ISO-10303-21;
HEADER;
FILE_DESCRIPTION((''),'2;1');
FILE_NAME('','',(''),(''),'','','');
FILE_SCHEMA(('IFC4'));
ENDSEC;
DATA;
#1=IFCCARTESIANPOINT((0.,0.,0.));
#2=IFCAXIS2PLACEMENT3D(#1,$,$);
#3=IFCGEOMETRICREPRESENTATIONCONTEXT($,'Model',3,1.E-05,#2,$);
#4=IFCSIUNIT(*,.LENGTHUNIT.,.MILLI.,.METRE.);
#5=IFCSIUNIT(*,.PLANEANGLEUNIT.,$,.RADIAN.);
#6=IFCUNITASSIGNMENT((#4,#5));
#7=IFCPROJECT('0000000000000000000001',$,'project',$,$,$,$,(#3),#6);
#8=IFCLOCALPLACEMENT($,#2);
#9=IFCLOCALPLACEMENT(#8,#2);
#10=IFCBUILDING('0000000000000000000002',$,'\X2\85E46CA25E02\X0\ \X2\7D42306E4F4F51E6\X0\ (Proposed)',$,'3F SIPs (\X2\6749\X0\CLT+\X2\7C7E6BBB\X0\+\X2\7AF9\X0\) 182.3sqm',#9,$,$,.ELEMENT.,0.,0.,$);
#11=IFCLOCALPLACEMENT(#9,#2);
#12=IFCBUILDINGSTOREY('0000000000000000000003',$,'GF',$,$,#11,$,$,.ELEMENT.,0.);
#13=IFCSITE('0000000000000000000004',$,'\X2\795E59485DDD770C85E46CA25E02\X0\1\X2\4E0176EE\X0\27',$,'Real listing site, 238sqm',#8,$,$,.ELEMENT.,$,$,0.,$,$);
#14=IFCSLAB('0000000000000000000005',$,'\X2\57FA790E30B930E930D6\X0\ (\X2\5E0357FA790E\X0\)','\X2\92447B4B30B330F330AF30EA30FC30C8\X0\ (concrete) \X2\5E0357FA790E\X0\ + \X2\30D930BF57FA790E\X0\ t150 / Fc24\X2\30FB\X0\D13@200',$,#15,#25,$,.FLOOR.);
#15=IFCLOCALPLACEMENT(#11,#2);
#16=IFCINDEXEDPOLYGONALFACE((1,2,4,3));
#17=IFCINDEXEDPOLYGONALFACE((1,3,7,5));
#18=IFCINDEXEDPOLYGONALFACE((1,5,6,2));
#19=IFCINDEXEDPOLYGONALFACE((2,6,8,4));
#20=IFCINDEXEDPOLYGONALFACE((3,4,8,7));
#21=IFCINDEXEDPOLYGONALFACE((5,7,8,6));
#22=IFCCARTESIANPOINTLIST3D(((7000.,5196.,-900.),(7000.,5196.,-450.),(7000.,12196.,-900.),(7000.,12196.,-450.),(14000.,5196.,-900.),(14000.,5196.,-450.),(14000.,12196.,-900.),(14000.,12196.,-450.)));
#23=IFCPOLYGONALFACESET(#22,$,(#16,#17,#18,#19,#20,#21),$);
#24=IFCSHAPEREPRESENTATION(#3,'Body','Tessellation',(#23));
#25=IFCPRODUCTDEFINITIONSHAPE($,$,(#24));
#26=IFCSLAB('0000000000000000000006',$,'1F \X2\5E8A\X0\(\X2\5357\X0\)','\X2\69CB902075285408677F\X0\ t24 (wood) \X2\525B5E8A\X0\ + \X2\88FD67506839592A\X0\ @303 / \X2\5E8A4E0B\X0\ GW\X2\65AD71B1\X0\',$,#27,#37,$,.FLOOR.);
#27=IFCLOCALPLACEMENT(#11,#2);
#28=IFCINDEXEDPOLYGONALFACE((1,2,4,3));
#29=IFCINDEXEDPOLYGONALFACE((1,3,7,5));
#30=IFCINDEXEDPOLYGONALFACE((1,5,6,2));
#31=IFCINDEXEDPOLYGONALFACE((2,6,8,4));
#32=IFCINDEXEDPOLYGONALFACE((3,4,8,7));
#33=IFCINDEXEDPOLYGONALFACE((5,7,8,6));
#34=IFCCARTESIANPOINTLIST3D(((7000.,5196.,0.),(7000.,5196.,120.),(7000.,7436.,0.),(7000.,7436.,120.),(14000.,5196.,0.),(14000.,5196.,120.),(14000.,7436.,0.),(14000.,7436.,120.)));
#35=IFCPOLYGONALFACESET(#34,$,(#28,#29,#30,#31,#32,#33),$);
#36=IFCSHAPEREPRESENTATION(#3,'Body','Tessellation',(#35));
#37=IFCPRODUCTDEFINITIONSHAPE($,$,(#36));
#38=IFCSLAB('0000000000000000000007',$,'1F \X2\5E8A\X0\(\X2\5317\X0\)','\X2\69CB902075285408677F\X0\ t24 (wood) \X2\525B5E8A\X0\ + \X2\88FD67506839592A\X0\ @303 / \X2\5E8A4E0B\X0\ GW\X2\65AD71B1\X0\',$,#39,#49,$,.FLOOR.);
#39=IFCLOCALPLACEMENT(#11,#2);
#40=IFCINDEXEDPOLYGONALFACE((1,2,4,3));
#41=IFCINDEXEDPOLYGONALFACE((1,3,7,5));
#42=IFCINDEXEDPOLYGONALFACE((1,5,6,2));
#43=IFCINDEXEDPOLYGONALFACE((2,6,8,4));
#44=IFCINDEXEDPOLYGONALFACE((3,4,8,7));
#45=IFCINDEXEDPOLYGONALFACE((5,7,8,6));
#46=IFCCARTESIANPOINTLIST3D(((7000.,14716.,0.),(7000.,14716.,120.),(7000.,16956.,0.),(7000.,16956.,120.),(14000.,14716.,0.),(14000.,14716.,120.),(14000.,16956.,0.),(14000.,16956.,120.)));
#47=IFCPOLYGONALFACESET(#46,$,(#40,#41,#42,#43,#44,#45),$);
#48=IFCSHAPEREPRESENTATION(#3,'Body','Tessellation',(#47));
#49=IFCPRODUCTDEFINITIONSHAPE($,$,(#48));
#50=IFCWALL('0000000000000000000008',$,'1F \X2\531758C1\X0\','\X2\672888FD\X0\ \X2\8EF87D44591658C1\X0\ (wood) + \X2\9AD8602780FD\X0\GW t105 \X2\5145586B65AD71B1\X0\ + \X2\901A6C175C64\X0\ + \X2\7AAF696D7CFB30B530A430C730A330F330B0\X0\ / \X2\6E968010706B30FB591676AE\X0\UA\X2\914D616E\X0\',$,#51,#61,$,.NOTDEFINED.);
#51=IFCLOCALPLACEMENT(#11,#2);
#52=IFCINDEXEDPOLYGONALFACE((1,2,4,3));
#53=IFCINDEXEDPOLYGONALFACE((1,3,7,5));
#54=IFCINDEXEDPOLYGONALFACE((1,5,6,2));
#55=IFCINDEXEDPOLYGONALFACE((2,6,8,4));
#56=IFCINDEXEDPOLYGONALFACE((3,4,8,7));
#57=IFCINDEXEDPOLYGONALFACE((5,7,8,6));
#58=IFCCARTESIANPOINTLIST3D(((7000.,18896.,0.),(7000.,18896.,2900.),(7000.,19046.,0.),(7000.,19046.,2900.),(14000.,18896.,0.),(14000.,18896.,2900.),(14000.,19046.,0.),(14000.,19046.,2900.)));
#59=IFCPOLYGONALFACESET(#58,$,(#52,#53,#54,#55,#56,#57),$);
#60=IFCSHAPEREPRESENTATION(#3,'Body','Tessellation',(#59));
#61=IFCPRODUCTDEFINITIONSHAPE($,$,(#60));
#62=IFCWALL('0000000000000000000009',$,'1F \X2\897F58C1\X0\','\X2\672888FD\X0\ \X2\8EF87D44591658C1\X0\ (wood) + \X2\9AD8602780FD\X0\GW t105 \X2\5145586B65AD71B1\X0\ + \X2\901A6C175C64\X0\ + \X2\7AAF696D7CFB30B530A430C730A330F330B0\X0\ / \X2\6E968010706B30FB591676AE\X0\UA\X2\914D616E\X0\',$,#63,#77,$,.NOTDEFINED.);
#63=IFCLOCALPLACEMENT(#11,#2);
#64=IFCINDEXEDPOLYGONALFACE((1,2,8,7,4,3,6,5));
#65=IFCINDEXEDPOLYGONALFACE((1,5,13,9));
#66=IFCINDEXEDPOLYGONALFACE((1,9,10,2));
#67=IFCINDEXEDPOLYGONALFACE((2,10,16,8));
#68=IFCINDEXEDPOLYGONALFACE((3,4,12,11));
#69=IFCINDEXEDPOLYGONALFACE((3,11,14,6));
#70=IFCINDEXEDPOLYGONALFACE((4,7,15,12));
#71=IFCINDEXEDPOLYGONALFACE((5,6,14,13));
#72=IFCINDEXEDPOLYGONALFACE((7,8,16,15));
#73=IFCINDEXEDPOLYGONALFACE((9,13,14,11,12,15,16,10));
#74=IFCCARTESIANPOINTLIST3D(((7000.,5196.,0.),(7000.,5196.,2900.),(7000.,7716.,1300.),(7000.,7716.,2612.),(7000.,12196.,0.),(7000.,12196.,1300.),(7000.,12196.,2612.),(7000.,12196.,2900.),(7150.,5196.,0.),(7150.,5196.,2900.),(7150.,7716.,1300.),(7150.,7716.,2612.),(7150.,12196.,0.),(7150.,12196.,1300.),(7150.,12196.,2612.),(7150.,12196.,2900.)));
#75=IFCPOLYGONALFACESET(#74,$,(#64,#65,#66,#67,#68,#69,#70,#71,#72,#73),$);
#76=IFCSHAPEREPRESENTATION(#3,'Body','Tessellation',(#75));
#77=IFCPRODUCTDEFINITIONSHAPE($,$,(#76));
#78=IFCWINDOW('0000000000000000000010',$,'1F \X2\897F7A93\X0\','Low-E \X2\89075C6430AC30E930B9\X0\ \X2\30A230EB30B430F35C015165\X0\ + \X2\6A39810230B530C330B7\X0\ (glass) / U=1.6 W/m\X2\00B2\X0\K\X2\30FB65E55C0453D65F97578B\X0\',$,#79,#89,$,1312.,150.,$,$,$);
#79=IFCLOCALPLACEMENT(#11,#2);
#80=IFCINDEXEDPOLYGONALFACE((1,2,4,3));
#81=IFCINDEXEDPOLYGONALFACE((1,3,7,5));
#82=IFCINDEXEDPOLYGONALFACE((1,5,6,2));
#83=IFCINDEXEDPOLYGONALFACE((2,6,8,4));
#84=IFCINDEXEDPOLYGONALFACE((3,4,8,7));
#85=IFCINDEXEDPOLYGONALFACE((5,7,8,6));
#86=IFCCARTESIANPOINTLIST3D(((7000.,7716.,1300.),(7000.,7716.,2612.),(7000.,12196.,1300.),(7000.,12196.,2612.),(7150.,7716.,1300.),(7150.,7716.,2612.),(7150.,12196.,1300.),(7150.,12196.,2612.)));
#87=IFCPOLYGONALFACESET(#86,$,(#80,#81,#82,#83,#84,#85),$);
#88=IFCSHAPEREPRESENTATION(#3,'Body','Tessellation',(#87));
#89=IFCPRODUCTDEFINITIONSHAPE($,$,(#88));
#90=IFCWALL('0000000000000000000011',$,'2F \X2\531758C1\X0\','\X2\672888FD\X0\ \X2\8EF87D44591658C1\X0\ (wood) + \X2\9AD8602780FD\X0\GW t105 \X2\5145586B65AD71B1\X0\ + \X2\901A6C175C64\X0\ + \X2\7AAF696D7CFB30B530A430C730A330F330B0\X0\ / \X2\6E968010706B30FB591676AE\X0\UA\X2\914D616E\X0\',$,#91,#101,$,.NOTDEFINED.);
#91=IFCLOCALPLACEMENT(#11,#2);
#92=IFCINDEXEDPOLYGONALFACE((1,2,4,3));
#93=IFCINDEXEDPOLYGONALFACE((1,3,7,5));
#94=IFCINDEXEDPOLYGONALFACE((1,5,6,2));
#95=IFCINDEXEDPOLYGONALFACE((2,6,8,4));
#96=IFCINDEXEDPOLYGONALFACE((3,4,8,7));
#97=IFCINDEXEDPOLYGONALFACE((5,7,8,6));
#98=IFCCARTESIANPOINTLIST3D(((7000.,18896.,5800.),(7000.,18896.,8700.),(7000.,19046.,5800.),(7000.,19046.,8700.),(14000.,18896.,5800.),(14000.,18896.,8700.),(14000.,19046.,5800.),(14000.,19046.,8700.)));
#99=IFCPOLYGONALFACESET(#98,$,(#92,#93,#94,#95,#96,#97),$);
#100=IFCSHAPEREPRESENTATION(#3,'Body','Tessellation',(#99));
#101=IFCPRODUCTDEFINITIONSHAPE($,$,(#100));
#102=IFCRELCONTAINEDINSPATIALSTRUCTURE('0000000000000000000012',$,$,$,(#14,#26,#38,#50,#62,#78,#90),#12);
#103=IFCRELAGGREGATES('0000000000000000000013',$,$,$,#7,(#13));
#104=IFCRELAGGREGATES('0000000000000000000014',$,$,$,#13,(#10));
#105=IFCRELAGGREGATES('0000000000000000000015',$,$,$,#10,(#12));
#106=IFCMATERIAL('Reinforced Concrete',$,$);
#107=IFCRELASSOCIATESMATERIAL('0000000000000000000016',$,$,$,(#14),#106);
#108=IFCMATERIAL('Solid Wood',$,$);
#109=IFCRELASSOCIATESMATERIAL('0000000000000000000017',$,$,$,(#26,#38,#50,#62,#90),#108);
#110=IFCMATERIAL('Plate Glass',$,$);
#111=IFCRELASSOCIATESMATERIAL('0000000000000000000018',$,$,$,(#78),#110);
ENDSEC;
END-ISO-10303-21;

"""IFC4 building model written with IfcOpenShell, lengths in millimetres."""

from ifc_helpers import new_model, si_unit, frame, frame_2d, origin, place, context, project, spatial, rectangle, extrude, material, element, fill, save


model = new_model("IFC4")

# Units and contexts
model_context = context("Model", 3, precision=1e-05, world=origin())
ifc_project = project(units=[si_unit("LENGTHUNIT", "METRE", prefix="MILLI"), si_unit("PLANEANGLEUNIT", "RADIAN")], contexts=[model_context])

# Site, building, storey
site_placement = place(None, origin())
site = spatial("IfcSite", under=ifc_project, at=site_placement, Name="神奈川県藤沢市1丁目27", ObjectType="Real listing site, 238sqm", CompositionType="ELEMENT", RefElevation=0.0)
building_placement = place(site_placement, origin())
building = spatial("IfcBuilding", under=site, at=building_placement, Name="藤沢市 終の住処 (Proposed)", ObjectType="3F SIPs (杉CLT+籾殻+竹) 182.3sqm", CompositionType="ELEMENT", ElevationOfRefHeight=0.0, ElevationOfTerrain=0.0)
storey_placement = place(building_placement, origin())
storey = spatial("IfcBuildingStorey", under=building, at=storey_placement, Name="GF", CompositionType="ELEMENT", Elevation=0.0)

# Slabs
ifc_material_1 = material(Name="Reinforced Concrete")
slab_1_placement = place(storey_placement, frame((3500.0, 2598.0, -450.0)))
element("IfcSlab", 1, at=slab_1_placement, inside=storey, material=ifc_material_1, Name="基礎スラブ (布基礎)", Description="鉄筋コンクリート (concrete) 布基礎 + ベタ基礎 t150 / Fc24・D13@200", PredefinedType="FLOOR", context=model_context, shape_type="SweptSolid", body=[
    extrude(rectangle(XDim=7000.0, YDim=7000.0, at=frame_2d((3500.0, 3500.0))), frame((3500.0, 2598.0, -450.0)), (0.0, 0.0, 1.0), 450.0),
])
ifc_material_2 = material(Name="Solid Wood")
slab_2_placement = place(storey_placement, frame((3500.0, 2598.0, 0.0)))
element("IfcSlab", 2, at=slab_2_placement, inside=storey, material=ifc_material_2, Name="1F 床(南)", Description="構造用合板 t24 (wood) 剛床 + 製材根太 @303 / 床下 GW断熱", PredefinedType="FLOOR", context=model_context, shape_type="SweptSolid", body=[
    extrude(rectangle(XDim=7000.0, YDim=2240.0, at=frame_2d((3500.0, 1120.0))), frame((3500.0, 2598.0, 0.0)), (0.0, 0.0, 1.0), 120.0),
])
slab_3_placement = place(storey_placement, frame((3500.0, 7358.0, 0.0)))
element("IfcSlab", 3, at=slab_3_placement, inside=storey, material=ifc_material_2, Name="1F 床(北)", Description="構造用合板 t24 (wood) 剛床 + 製材根太 @303 / 床下 GW断熱", PredefinedType="FLOOR", context=model_context, shape_type="SweptSolid", body=[
    extrude(rectangle(XDim=7000.0, YDim=2240.0, at=frame_2d((3500.0, 1120.0))), frame((3500.0, 7358.0, 0.0)), (0.0, 0.0, 1.0), 120.0),
])

# Shared definitions
ifc_material_3 = material(Name="Plate Glass")

# Wall
wall_1_placement = place(storey_placement, frame((3500.0, 9448.0, 0.0)))
element("IfcWall", 4, at=wall_1_placement, inside=storey, material=ifc_material_2, Name="1F 北壁", Description="木製 軸組外壁 (wood) + 高性能GW t105 充填断熱 + 通気層 + 窯業系サイディング / 準耐火・外皮UA配慮", PredefinedType="NOTDEFINED", context=model_context, shape_type="SweptSolid", body=[
    extrude(rectangle(XDim=7000.0, YDim=150.0, at=frame_2d((3500.0, 75.0))), frame((3500.0, 9448.0, 0.0)), (0.0, 0.0, 1.0), 2900.0),
])

# Wall, opening, window
wall_2_placement = place(storey_placement, frame((3500.0, 2598.0, 0.0)))
wall_2 = element("IfcWall", 5, at=wall_2_placement, inside=storey, material=ifc_material_2, Name="1F 西壁", Description="木製 軸組外壁 (wood) + 高性能GW t105 充填断熱 + 通気層 + 窯業系サイディング / 準耐火・外皮UA配慮", PredefinedType="NOTDEFINED", context=model_context, shape_type="SweptSolid", body=[
    extrude(rectangle(XDim=150.0, YDim=7000.0, at=frame_2d((75.0, 3500.0))), frame((3500.0, 2598.0, 0.0)), (0.0, 0.0, 1.0), 2900.0),
])
opening_1_placement = place(storey_placement, frame((3500.0, 3858.0, 650.0)))
opening_1 = element("IfcOpeningElement", 6, at=opening_1_placement, cuts=wall_2, PredefinedType="NOTDEFINED", context=model_context, shape_type="SweptSolid", body=[
    extrude(rectangle(XDim=150.0, YDim=4480.0, at=frame_2d((75.0, 2240.0))), frame((3500.0, 3858.0, 650.0)), (0.0, 0.0, 1.0), 1312.0),
])
window_1_placement = place(storey_placement, frame((3500.0, 3858.0, 650.0)))
window_1 = element("IfcWindow", 7, at=window_1_placement, inside=storey, material=ifc_material_3, Name="1F 西窓", Description="Low-E 複層ガラス アルゴン封入 + 樹脂サッシ (glass) / U=1.6 W/m²K・日射取得型", OverallHeight=1312.0, OverallWidth=150.0, context=model_context, shape_type="SweptSolid", body=[
    extrude(rectangle(XDim=150.0, YDim=4480.0, at=frame_2d((75.0, 2240.0))), frame((3500.0, 3858.0, 650.0)), (0.0, 0.0, 1.0), 1312.0),
])
fill(opening_1, window_1)

# Wall
wall_3_placement = place(storey_placement, frame((3500.0, 9448.0, 2900.0)))
element("IfcWall", 8, at=wall_3_placement, inside=storey, material=ifc_material_2, Name="2F 北壁", Description="木製 軸組外壁 (wood) + 高性能GW t105 充填断熱 + 通気層 + 窯業系サイディング / 準耐火・外皮UA配慮", PredefinedType="NOTDEFINED", context=model_context, shape_type="SweptSolid", body=[
    extrude(rectangle(XDim=7000.0, YDim=150.0, at=frame_2d((3500.0, 75.0))), frame((3500.0, 9448.0, 2900.0)), (0.0, 0.0, 1.0), 2900.0),
])

save(model, "model.ifc")
